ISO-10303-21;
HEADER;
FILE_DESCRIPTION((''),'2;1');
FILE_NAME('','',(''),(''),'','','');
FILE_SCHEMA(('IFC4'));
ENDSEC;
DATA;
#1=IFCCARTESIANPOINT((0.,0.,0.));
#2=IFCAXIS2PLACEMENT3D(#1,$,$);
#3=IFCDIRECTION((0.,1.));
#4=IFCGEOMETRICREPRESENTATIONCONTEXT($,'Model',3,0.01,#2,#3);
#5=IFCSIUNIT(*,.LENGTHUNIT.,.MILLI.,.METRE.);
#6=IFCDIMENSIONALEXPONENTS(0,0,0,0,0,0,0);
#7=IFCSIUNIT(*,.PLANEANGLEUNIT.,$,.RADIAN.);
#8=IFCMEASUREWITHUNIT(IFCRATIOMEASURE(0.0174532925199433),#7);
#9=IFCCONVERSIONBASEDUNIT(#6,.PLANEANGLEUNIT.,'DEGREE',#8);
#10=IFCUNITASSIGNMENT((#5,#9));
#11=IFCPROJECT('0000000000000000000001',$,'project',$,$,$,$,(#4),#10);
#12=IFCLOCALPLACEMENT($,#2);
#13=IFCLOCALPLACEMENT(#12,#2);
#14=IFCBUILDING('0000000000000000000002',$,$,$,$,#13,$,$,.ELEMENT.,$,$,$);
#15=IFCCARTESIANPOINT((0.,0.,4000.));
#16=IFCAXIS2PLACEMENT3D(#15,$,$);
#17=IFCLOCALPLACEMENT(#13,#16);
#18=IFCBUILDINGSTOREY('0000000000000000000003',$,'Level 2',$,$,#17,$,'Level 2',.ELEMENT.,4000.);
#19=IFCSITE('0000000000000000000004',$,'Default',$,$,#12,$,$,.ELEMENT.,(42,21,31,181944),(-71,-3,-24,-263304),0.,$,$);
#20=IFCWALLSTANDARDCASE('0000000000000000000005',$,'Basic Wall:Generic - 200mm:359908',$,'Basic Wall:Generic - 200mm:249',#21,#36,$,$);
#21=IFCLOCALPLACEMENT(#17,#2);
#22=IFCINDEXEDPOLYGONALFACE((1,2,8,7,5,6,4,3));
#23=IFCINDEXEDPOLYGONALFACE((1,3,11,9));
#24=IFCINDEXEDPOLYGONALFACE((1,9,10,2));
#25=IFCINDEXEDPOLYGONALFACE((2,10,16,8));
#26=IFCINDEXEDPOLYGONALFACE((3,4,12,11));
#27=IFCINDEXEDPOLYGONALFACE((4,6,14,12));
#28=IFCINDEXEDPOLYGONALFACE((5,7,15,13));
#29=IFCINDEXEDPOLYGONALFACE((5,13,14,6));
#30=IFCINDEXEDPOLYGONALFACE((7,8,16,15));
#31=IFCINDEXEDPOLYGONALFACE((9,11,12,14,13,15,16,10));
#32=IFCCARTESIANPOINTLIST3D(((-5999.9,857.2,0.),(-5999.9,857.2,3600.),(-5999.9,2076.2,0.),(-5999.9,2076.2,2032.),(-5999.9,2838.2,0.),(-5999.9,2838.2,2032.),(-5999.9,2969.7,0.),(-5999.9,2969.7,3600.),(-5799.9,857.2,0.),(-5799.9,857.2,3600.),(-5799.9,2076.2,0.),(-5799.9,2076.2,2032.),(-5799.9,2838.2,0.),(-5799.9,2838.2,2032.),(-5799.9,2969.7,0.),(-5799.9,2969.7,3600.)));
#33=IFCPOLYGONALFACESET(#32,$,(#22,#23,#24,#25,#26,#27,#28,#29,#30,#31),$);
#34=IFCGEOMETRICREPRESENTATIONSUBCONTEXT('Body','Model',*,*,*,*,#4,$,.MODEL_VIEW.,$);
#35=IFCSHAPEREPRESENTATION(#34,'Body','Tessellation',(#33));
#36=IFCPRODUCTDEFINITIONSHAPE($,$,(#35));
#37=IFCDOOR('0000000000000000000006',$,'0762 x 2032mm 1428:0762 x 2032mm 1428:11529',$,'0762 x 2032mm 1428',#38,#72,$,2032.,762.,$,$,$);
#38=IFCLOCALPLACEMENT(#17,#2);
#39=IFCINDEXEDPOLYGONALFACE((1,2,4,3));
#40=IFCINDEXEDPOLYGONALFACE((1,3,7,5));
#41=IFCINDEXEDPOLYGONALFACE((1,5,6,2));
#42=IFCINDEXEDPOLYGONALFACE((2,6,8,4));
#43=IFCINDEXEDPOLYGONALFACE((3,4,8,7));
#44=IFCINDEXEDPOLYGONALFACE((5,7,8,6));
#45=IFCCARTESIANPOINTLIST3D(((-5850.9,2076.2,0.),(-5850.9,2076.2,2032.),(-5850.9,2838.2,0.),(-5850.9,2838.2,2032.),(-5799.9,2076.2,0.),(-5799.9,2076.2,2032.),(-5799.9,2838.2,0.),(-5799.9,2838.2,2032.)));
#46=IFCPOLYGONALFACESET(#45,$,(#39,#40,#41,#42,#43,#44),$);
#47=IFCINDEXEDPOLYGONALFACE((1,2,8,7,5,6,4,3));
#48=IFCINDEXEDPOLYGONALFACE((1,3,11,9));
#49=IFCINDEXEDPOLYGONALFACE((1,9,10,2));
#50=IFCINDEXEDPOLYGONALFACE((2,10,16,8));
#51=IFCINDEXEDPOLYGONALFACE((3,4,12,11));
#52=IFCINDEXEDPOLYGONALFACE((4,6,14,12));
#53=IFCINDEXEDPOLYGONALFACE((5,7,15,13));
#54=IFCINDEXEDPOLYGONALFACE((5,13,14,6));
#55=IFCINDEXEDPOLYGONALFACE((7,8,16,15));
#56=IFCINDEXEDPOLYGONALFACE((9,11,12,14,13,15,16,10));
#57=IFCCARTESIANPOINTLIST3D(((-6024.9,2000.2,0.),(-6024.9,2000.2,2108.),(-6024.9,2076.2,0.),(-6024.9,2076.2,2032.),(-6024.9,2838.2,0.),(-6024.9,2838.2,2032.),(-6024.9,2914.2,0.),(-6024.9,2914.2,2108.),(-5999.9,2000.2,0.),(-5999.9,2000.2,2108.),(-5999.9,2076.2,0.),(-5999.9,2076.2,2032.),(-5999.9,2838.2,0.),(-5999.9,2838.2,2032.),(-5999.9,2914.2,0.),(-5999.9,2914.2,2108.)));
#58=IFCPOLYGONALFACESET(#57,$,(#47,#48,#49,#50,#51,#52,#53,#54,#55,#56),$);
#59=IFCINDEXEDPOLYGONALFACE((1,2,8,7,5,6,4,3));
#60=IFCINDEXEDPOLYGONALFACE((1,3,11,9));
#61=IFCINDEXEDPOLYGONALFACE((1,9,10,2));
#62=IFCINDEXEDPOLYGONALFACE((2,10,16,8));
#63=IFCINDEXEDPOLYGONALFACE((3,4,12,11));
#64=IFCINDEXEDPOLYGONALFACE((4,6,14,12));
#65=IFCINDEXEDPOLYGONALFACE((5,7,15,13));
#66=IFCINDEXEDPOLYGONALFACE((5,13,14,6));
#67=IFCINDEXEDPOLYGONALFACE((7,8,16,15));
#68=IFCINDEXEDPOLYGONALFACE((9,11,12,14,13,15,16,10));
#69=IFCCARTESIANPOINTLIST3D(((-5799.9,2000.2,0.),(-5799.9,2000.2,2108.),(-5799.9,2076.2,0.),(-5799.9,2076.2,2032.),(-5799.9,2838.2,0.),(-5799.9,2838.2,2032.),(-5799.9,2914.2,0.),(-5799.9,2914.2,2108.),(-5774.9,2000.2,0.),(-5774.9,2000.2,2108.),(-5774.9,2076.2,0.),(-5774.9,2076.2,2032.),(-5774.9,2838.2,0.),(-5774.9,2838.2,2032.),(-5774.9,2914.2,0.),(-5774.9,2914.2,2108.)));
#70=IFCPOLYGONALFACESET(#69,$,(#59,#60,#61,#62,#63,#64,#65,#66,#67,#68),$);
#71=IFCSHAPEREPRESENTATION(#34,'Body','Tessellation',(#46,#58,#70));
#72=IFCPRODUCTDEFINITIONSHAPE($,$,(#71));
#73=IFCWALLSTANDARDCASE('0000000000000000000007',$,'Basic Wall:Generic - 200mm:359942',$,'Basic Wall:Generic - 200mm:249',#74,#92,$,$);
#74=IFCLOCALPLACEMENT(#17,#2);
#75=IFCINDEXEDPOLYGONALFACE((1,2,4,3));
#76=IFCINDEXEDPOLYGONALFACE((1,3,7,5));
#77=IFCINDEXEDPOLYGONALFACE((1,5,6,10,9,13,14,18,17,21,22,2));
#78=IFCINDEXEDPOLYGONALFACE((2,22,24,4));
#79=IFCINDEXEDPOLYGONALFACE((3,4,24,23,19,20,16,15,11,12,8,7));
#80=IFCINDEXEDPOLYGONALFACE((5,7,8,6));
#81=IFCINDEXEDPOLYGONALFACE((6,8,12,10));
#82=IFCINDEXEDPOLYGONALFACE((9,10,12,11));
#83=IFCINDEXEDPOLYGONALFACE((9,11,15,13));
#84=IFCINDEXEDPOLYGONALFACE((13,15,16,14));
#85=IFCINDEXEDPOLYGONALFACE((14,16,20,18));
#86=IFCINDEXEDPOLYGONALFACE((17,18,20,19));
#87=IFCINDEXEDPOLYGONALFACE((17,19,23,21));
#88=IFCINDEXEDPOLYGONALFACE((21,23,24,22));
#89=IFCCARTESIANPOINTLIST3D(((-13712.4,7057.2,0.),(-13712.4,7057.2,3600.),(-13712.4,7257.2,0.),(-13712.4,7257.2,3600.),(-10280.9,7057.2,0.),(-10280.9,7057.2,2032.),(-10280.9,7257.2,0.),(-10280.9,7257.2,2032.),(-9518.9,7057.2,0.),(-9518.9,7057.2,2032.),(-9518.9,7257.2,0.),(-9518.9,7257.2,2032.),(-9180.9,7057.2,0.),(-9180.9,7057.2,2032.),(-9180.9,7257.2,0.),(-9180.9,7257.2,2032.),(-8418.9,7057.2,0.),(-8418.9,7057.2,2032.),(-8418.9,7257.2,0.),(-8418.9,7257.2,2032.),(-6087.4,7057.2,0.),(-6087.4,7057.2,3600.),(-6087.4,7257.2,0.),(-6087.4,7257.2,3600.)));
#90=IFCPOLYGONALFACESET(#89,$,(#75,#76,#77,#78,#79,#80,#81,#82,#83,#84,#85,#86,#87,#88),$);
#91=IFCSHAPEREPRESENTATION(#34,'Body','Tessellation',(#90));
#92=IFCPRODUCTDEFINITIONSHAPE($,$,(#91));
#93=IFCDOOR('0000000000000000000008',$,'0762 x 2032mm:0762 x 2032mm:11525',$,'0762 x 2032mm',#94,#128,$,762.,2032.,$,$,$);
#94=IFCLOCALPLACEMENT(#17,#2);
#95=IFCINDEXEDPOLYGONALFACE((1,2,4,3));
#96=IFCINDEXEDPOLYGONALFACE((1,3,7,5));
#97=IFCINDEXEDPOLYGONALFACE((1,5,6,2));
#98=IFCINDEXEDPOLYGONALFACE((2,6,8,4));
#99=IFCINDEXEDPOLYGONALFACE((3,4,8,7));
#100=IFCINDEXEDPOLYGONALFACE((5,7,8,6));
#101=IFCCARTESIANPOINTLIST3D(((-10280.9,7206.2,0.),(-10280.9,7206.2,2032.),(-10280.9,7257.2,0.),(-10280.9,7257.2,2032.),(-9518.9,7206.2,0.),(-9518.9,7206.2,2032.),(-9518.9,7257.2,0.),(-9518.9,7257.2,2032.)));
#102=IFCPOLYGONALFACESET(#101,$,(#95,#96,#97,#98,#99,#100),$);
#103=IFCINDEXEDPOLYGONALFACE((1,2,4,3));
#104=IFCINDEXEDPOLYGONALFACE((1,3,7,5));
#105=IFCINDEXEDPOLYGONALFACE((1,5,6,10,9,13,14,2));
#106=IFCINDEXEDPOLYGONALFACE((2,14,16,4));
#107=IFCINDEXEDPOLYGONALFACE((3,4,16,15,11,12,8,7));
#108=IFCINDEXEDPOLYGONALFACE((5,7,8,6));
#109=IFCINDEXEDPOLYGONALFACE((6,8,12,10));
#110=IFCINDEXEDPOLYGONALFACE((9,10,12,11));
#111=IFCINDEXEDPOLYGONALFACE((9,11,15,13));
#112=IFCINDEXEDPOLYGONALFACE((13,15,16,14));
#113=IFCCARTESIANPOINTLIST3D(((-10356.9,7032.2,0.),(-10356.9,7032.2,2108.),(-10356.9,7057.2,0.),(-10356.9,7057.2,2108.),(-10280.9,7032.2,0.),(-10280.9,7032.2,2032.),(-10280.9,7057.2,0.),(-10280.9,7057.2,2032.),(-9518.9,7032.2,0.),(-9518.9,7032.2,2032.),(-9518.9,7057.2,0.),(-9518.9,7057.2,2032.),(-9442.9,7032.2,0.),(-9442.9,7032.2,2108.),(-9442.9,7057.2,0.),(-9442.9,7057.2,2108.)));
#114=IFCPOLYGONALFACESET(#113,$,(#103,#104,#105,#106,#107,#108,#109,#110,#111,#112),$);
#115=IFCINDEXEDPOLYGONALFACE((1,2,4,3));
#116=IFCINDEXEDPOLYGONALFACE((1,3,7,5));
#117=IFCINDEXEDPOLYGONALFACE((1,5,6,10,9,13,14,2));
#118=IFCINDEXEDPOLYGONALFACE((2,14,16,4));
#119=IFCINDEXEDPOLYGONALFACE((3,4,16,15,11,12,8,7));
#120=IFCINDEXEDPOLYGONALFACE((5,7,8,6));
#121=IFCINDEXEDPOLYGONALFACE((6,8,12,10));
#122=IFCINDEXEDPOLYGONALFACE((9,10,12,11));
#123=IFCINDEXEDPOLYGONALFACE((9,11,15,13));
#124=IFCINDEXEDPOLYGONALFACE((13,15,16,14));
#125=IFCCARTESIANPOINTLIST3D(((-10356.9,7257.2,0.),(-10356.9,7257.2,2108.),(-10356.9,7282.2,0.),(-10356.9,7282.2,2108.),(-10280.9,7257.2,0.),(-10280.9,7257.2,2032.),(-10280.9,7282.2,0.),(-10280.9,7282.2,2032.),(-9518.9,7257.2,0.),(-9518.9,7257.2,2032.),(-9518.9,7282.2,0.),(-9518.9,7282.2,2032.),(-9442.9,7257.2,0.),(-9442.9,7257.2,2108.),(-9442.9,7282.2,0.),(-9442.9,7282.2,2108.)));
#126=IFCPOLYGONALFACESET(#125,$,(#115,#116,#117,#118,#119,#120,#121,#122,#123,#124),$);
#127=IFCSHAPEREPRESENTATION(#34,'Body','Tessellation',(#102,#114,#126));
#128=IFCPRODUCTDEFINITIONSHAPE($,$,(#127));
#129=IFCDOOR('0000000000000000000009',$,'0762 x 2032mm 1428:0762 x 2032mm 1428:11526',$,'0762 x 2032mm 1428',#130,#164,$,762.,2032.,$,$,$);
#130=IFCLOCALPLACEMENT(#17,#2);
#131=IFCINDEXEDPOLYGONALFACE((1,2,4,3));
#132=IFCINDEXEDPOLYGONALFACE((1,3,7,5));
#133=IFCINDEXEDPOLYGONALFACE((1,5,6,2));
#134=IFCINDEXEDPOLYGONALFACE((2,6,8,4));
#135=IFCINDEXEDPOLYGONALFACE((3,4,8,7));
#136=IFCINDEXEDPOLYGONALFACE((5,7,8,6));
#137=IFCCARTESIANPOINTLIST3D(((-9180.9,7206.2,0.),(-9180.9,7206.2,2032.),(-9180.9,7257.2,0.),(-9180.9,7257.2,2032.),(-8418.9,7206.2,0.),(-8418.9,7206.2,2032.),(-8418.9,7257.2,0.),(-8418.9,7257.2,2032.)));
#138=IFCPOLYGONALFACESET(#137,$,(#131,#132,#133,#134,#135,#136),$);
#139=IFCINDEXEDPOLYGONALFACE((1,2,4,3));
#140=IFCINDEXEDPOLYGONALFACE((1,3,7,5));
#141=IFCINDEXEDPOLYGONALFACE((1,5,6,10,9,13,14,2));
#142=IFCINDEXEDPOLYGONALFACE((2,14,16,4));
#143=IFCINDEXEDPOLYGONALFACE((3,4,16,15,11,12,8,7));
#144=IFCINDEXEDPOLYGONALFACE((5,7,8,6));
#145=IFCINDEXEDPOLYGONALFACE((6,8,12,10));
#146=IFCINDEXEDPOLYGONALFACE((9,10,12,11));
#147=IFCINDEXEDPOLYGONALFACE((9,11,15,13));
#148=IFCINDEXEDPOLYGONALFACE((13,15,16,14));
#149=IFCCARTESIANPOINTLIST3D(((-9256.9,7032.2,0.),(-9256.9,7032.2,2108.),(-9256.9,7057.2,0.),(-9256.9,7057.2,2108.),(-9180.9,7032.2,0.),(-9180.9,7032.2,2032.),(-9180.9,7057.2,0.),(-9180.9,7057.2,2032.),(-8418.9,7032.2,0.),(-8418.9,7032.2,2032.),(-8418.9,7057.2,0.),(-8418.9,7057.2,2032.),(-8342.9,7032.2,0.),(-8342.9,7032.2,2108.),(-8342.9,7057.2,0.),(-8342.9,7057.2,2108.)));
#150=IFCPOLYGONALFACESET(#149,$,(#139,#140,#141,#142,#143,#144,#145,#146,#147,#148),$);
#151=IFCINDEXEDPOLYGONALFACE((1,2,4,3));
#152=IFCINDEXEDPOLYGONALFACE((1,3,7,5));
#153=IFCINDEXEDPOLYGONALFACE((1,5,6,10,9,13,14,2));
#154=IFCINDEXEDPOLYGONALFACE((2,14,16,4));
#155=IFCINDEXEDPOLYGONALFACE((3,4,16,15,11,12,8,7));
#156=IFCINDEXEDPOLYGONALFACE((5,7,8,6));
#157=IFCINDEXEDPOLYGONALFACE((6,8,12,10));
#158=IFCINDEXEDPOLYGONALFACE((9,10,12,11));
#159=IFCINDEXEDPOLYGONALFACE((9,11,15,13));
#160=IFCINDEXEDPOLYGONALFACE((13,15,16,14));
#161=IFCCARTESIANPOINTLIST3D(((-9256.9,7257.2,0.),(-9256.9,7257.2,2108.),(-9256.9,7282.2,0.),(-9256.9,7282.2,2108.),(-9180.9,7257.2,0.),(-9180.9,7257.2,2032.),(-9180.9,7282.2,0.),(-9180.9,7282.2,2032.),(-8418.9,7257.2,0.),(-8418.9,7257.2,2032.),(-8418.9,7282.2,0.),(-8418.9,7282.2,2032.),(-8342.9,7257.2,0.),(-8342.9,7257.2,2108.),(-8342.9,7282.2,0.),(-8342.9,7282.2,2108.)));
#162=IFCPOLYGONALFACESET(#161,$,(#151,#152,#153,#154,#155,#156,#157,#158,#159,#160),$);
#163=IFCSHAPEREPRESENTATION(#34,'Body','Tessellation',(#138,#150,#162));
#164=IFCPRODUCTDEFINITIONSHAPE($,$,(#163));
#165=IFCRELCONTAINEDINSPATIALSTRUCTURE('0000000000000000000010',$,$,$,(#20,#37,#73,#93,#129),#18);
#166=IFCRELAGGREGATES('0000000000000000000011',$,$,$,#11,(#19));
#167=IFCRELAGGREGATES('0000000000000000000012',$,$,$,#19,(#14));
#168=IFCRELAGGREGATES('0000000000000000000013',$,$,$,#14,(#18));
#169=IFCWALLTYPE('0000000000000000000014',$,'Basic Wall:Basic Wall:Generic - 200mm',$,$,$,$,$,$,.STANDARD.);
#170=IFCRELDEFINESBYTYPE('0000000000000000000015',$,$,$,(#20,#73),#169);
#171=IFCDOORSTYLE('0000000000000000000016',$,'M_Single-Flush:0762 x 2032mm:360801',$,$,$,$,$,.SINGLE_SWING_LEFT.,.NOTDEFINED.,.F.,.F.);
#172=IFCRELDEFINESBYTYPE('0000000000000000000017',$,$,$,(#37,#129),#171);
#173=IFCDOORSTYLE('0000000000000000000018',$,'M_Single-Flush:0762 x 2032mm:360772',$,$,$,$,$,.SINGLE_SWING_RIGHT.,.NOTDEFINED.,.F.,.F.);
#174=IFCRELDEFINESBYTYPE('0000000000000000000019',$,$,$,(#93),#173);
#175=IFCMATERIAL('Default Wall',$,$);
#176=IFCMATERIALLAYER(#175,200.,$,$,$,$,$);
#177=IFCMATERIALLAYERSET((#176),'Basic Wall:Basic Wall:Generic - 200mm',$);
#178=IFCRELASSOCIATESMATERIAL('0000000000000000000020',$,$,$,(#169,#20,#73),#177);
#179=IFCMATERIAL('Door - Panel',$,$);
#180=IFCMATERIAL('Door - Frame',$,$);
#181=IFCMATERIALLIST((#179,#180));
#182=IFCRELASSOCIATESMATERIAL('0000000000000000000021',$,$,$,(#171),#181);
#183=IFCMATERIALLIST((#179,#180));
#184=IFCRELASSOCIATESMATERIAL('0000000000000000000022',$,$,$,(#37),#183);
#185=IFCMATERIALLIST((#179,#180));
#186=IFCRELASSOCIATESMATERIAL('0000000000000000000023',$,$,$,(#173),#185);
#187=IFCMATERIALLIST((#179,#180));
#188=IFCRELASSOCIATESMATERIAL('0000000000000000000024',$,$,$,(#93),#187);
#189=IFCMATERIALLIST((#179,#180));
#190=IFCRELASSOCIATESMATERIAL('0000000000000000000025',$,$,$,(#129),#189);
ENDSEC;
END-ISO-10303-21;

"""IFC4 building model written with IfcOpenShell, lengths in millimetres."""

from ifc_helpers import new_model, entity, si_unit, converted_unit, direction, frame, frame_2d, origin, origin_2d_with_axis, place, context, subcontext, project, spatial, polyline, rectangle, outline, extrude, source, transform, mapped, material, material_list, layer, layer_set, layer_usage, type_object, type_shapes, element, fill, save


model = new_model("IFC4")

# Units and contexts
model_context = context("Model", 3, precision=0.01, world=origin(), true_north=direction((0.0, 1.0)))
body_context = subcontext(model_context, "Body", "Model", "MODEL_VIEW")
ifc_project = project(units=[si_unit("LENGTHUNIT", "METRE", prefix="MILLI"), converted_unit("PLANEANGLEUNIT", "DEGREE", entity("IfcRatioMeasure", 0.0174532925199433), si_unit("PLANEANGLEUNIT", "RADIAN"), dimensions=[0, 0, 0, 0, 0, 0, 0])], contexts=[model_context])

# Site, building, storey
site_placement = place(None, origin())
site = spatial("IfcSite", under=ifc_project, at=site_placement, Name="Default", CompositionType="ELEMENT", RefLatitude=(42, 21, 31, 181944), RefLongitude=(-71, -3, -24, -263304), RefElevation=0.0)
building_placement = place(site_placement, origin())
building = spatial("IfcBuilding", under=site, at=building_placement, CompositionType="ELEMENT")
storey_placement = place(building_placement, frame((0.0, 0.0, 4000.0)))
storey = spatial("IfcBuildingStorey", under=building, at=storey_placement, Name="Level 2", LongName="Level 2", CompositionType="ELEMENT", Elevation=4000.0)

# Shared definitions
ifc_material_1 = material(Name="Default Wall")
ifc_material_2 = material(Name="Door - Panel")
ifc_material_3 = material(Name="Door - Frame")

# Wall, opening, door
ifc_layer_1 = layer(ifc_material_1, 200.0)
ifc_layer_set_1 = layer_set([ifc_layer_1], Name="Basic Wall:Basic Wall:Generic - 200mm")
ifc_layer_usage_1 = layer_usage(ifc_layer_set_1, "AXIS2", "NEGATIVE", 100.0)
wall_type_1 = type_object("IfcWallType", Name="Basic Wall:Basic Wall:Generic - 200mm", PredefinedType="STANDARD", material=ifc_layer_set_1)
wall_1_placement = place(storey_placement, frame((-5899.9, 857.2, 0.0), z_axis=(0.0, 0.0, 1.0), x_axis=(0.0, 1.0, 0.0)))
wall_1 = element("IfcWallStandardCase", 1, at=wall_1_placement, inside=storey, type_object=wall_type_1, material=ifc_layer_usage_1, Name="Basic Wall:Generic - 200mm:359908", ObjectType="Basic Wall:Generic - 200mm:249", context=body_context, shape_type="SweptSolid", body=[
    extrude(rectangle(XDim=2112.5, YDim=200.0, at=frame_2d((1056.2, 0.0), x_axis=(-1.0, 0.0))), origin(), (0.0, 0.0, 1.0), 3600.0),
])
opening_1_placement = place(wall_1_placement, frame((-857.2, -5899.9, 0.0), z_axis=(0.0, 0.0, 1.0), x_axis=(0.0, -1.0, 0.0)))
opening_1 = element("IfcOpeningElement", 2, at=opening_1_placement, cuts=wall_1, ObjectType="Opening", context=body_context, shape_type="SweptSolid", body=[
    extrude(rectangle(XDim=2032.0, YDim=762.0, at=frame_2d((0.0, 0.0), x_axis=(0.0, 1.0))), frame((-5797.9, 2457.2, 1016.0), z_axis=(-1.0, 0.0, 0.0), x_axis=(0.0, -1.0, 0.0)), (0.0, 0.0, 1.0), 204.0),
])
ifc_material_list_1 = material_list([ifc_material_2, ifc_material_3])
ifc_material_list_2 = material_list([ifc_material_2, ifc_material_3])
door_style_1 = type_object("IfcDoorStyle", Name="M_Single-Flush:0762 x 2032mm:360801", ConstructionType="NOTDEFINED", OperationType="SINGLE_SWING_LEFT", ParameterTakesPrecedence=False, Sizeable=False, material=ifc_material_list_2)
shared_shape_1 = source(origin(), body_context, "Body", "SweptSolid", [
    extrude(rectangle(XDim=51.0, YDim=762.0, at=origin_2d_with_axis()), frame((381.0, -27.5, 0.0), z_axis=(0.0, 0.0, 1.0), x_axis=(0.0, 1.0, 0.0)), (0.0, 0.0, 1.0), 2032.0),
    extrude(outline(polyline([(-1035.0, -457.0), (1073.0, -457.0), (1073.0, 457.0), (-1035.0, 457.0), (-1035.0, 381.0), (997.0, 381.0), (997.0, -381.0), (-1035.0, -381.0), (-1035.0, -457.0)])), frame((381.0, -227.0, 1035.0), z_axis=(0.0, 1.0, 0.0), x_axis=(0.0, 0.0, 1.0)), (0.0, 0.0, 1.0), 25.0),
    extrude(outline(polyline([(-457.0, -1073.0), (457.0, -1073.0), (457.0, 1035.0), (381.0, 1035.0), (381.0, -997.0), (-381.0, -997.0), (-381.0, 1035.0), (-457.0, 1035.0), (-457.0, -1073.0)])), frame((381.0, -2.0, 1035.0), z_axis=(0.0, 1.0, 0.0), x_axis=(1.0, 0.0, 0.0)), (0.0, 0.0, 1.0), 25.0),
])
type_shapes(door_style_1, [shared_shape_1])
door_1_placement = place(opening_1_placement, frame((-5797.9, 2838.2, 0.0), z_axis=(0.0, 0.0, 1.0), x_axis=(0.0, -1.0, 0.0)))
door_1 = element("IfcDoor", 3, at=door_1_placement, inside=storey, type_object=door_style_1, material=ifc_material_list_1, Name="0762 x 2032mm 1428:0762 x 2032mm 1428:11529", ObjectType="0762 x 2032mm 1428", OverallHeight=2032.0, OverallWidth=762.0, context=body_context, shape_type="MappedRepresentation", body=[
    mapped(shared_shape_1, transform((0.0, 0.0, 0.0), scale=1.0)),
])
fill(opening_1, door_1)

# Wall, openings, doors
ifc_layer_usage_2 = layer_usage(ifc_layer_set_1, "AXIS2", "NEGATIVE", 100.0)
wall_2_placement = place(storey_placement, frame((-13712.4, 7157.2, 0.0)))
wall_2 = element("IfcWallStandardCase", 4, at=wall_2_placement, inside=storey, type_object=wall_type_1, material=ifc_layer_usage_2, Name="Basic Wall:Generic - 200mm:359942", ObjectType="Basic Wall:Generic - 200mm:249", context=body_context, shape_type="SweptSolid", body=[
    extrude(rectangle(XDim=7625.0, YDim=200.0, at=frame_2d((3812.5, 0.0), x_axis=(-1.0, 0.0))), origin(), (0.0, 0.0, 1.0), 3600.0),
])
opening_2_placement = place(wall_2_placement, frame((13712.4, -7157.2, 0.0)))
opening_2 = element("IfcOpeningElement", 5, at=opening_2_placement, cuts=wall_2, ObjectType="Opening", context=body_context, shape_type="SweptSolid", body=[
    extrude(rectangle(XDim=2032.0, YDim=762.0, at=frame_2d((0.0, 0.0), x_axis=(1.0, 0.0))), frame((-9899.9, 7055.2, 1016.0), z_axis=(0.0, 1.0, 0.0), x_axis=(0.0, 0.0, -1.0)), (0.0, 0.0, 1.0), 204.0),
])
opening_3_placement = place(wall_2_placement, frame((13712.4, -7157.2, 0.0)))
opening_3 = element("IfcOpeningElement", 6, at=opening_3_placement, cuts=wall_2, ObjectType="Opening", context=body_context, shape_type="SweptSolid", body=[
    extrude(rectangle(XDim=2032.0, YDim=762.0, at=frame_2d((0.0, 0.0), x_axis=(1.0, 0.0))), frame((-8799.9, 7055.2, 1016.0), z_axis=(0.0, 1.0, 0.0), x_axis=(0.0, 0.0, 1.0)), (0.0, 0.0, 1.0), 204.0),
])
ifc_material_list_3 = material_list([ifc_material_2, ifc_material_3])
ifc_material_list_4 = material_list([ifc_material_2, ifc_material_3])
door_style_2 = type_object("IfcDoorStyle", Name="M_Single-Flush:0762 x 2032mm:360772", ConstructionType="NOTDEFINED", OperationType="SINGLE_SWING_RIGHT", ParameterTakesPrecedence=False, Sizeable=False, material=ifc_material_list_4)
shared_shape_2 = source(origin(), body_context, "Body", "SweptSolid", [
    extrude(rectangle(XDim=762.0, YDim=51.0, at=frame_2d((0.0, 0.0), x_axis=(1.0, 0.0))), frame((381.0, -27.5, 0.0), z_axis=(0.0, 0.0, 1.0), x_axis=(-1.0, 0.0, 0.0)), (0.0, 0.0, 1.0), 2032.0),
    extrude(outline(polyline([(-457.0, -1035.0), (-381.0, -1035.0), (-381.0, 997.0), (381.0, 997.0), (381.0, -1035.0), (457.0, -1035.0), (457.0, 1073.0), (-457.0, 1073.0), (-457.0, -1035.0)])), frame((381.0, -227.0, 1035.0), z_axis=(0.0, 1.0, 0.0), x_axis=(-1.0, 0.0, 0.0)), (0.0, 0.0, 1.0), 25.0),
    extrude(outline(polyline([(-1073.0, -457.0), (1035.0, -457.0), (1035.0, -381.0), (-997.0, -381.0), (-997.0, 381.0), (1035.0, 381.0), (1035.0, 457.0), (-1073.0, 457.0), (-1073.0, -457.0)])), frame((381.0, -2.0, 1035.0), z_axis=(0.0, 1.0, 0.0), x_axis=(0.0, 0.0, -1.0)), (0.0, 0.0, 1.0), 25.0),
])
type_shapes(door_style_2, [shared_shape_2])
door_2_placement = place(opening_2_placement, frame((-10280.9, 7259.2, 0.0)))
door_2 = element("IfcDoor", 7, at=door_2_placement, inside=storey, type_object=door_style_2, material=ifc_material_list_3, Name="0762 x 2032mm:0762 x 2032mm:11525", ObjectType="0762 x 2032mm", OverallHeight=762.0, OverallWidth=2032.0, context=body_context, shape_type="MappedRepresentation", body=[
    mapped(shared_shape_2, transform((0.0, 0.0, 0.0), scale=1.0)),
])
fill(opening_2, door_2)
ifc_material_list_5 = material_list([ifc_material_2, ifc_material_3])
door_3_placement = place(opening_3_placement, frame((-9180.9, 7259.2, 0.0)))
door_3 = element("IfcDoor", 8, at=door_3_placement, inside=storey, type_object=door_style_1, material=ifc_material_list_5, Name="0762 x 2032mm 1428:0762 x 2032mm 1428:11526", ObjectType="0762 x 2032mm 1428", OverallHeight=762.0, OverallWidth=2032.0, context=body_context, shape_type="MappedRepresentation", body=[
    mapped(shared_shape_1, transform((0.0, 0.0, 0.0), scale=1.0)),
])
fill(opening_3, door_3)

save(model, "model.ifc")
